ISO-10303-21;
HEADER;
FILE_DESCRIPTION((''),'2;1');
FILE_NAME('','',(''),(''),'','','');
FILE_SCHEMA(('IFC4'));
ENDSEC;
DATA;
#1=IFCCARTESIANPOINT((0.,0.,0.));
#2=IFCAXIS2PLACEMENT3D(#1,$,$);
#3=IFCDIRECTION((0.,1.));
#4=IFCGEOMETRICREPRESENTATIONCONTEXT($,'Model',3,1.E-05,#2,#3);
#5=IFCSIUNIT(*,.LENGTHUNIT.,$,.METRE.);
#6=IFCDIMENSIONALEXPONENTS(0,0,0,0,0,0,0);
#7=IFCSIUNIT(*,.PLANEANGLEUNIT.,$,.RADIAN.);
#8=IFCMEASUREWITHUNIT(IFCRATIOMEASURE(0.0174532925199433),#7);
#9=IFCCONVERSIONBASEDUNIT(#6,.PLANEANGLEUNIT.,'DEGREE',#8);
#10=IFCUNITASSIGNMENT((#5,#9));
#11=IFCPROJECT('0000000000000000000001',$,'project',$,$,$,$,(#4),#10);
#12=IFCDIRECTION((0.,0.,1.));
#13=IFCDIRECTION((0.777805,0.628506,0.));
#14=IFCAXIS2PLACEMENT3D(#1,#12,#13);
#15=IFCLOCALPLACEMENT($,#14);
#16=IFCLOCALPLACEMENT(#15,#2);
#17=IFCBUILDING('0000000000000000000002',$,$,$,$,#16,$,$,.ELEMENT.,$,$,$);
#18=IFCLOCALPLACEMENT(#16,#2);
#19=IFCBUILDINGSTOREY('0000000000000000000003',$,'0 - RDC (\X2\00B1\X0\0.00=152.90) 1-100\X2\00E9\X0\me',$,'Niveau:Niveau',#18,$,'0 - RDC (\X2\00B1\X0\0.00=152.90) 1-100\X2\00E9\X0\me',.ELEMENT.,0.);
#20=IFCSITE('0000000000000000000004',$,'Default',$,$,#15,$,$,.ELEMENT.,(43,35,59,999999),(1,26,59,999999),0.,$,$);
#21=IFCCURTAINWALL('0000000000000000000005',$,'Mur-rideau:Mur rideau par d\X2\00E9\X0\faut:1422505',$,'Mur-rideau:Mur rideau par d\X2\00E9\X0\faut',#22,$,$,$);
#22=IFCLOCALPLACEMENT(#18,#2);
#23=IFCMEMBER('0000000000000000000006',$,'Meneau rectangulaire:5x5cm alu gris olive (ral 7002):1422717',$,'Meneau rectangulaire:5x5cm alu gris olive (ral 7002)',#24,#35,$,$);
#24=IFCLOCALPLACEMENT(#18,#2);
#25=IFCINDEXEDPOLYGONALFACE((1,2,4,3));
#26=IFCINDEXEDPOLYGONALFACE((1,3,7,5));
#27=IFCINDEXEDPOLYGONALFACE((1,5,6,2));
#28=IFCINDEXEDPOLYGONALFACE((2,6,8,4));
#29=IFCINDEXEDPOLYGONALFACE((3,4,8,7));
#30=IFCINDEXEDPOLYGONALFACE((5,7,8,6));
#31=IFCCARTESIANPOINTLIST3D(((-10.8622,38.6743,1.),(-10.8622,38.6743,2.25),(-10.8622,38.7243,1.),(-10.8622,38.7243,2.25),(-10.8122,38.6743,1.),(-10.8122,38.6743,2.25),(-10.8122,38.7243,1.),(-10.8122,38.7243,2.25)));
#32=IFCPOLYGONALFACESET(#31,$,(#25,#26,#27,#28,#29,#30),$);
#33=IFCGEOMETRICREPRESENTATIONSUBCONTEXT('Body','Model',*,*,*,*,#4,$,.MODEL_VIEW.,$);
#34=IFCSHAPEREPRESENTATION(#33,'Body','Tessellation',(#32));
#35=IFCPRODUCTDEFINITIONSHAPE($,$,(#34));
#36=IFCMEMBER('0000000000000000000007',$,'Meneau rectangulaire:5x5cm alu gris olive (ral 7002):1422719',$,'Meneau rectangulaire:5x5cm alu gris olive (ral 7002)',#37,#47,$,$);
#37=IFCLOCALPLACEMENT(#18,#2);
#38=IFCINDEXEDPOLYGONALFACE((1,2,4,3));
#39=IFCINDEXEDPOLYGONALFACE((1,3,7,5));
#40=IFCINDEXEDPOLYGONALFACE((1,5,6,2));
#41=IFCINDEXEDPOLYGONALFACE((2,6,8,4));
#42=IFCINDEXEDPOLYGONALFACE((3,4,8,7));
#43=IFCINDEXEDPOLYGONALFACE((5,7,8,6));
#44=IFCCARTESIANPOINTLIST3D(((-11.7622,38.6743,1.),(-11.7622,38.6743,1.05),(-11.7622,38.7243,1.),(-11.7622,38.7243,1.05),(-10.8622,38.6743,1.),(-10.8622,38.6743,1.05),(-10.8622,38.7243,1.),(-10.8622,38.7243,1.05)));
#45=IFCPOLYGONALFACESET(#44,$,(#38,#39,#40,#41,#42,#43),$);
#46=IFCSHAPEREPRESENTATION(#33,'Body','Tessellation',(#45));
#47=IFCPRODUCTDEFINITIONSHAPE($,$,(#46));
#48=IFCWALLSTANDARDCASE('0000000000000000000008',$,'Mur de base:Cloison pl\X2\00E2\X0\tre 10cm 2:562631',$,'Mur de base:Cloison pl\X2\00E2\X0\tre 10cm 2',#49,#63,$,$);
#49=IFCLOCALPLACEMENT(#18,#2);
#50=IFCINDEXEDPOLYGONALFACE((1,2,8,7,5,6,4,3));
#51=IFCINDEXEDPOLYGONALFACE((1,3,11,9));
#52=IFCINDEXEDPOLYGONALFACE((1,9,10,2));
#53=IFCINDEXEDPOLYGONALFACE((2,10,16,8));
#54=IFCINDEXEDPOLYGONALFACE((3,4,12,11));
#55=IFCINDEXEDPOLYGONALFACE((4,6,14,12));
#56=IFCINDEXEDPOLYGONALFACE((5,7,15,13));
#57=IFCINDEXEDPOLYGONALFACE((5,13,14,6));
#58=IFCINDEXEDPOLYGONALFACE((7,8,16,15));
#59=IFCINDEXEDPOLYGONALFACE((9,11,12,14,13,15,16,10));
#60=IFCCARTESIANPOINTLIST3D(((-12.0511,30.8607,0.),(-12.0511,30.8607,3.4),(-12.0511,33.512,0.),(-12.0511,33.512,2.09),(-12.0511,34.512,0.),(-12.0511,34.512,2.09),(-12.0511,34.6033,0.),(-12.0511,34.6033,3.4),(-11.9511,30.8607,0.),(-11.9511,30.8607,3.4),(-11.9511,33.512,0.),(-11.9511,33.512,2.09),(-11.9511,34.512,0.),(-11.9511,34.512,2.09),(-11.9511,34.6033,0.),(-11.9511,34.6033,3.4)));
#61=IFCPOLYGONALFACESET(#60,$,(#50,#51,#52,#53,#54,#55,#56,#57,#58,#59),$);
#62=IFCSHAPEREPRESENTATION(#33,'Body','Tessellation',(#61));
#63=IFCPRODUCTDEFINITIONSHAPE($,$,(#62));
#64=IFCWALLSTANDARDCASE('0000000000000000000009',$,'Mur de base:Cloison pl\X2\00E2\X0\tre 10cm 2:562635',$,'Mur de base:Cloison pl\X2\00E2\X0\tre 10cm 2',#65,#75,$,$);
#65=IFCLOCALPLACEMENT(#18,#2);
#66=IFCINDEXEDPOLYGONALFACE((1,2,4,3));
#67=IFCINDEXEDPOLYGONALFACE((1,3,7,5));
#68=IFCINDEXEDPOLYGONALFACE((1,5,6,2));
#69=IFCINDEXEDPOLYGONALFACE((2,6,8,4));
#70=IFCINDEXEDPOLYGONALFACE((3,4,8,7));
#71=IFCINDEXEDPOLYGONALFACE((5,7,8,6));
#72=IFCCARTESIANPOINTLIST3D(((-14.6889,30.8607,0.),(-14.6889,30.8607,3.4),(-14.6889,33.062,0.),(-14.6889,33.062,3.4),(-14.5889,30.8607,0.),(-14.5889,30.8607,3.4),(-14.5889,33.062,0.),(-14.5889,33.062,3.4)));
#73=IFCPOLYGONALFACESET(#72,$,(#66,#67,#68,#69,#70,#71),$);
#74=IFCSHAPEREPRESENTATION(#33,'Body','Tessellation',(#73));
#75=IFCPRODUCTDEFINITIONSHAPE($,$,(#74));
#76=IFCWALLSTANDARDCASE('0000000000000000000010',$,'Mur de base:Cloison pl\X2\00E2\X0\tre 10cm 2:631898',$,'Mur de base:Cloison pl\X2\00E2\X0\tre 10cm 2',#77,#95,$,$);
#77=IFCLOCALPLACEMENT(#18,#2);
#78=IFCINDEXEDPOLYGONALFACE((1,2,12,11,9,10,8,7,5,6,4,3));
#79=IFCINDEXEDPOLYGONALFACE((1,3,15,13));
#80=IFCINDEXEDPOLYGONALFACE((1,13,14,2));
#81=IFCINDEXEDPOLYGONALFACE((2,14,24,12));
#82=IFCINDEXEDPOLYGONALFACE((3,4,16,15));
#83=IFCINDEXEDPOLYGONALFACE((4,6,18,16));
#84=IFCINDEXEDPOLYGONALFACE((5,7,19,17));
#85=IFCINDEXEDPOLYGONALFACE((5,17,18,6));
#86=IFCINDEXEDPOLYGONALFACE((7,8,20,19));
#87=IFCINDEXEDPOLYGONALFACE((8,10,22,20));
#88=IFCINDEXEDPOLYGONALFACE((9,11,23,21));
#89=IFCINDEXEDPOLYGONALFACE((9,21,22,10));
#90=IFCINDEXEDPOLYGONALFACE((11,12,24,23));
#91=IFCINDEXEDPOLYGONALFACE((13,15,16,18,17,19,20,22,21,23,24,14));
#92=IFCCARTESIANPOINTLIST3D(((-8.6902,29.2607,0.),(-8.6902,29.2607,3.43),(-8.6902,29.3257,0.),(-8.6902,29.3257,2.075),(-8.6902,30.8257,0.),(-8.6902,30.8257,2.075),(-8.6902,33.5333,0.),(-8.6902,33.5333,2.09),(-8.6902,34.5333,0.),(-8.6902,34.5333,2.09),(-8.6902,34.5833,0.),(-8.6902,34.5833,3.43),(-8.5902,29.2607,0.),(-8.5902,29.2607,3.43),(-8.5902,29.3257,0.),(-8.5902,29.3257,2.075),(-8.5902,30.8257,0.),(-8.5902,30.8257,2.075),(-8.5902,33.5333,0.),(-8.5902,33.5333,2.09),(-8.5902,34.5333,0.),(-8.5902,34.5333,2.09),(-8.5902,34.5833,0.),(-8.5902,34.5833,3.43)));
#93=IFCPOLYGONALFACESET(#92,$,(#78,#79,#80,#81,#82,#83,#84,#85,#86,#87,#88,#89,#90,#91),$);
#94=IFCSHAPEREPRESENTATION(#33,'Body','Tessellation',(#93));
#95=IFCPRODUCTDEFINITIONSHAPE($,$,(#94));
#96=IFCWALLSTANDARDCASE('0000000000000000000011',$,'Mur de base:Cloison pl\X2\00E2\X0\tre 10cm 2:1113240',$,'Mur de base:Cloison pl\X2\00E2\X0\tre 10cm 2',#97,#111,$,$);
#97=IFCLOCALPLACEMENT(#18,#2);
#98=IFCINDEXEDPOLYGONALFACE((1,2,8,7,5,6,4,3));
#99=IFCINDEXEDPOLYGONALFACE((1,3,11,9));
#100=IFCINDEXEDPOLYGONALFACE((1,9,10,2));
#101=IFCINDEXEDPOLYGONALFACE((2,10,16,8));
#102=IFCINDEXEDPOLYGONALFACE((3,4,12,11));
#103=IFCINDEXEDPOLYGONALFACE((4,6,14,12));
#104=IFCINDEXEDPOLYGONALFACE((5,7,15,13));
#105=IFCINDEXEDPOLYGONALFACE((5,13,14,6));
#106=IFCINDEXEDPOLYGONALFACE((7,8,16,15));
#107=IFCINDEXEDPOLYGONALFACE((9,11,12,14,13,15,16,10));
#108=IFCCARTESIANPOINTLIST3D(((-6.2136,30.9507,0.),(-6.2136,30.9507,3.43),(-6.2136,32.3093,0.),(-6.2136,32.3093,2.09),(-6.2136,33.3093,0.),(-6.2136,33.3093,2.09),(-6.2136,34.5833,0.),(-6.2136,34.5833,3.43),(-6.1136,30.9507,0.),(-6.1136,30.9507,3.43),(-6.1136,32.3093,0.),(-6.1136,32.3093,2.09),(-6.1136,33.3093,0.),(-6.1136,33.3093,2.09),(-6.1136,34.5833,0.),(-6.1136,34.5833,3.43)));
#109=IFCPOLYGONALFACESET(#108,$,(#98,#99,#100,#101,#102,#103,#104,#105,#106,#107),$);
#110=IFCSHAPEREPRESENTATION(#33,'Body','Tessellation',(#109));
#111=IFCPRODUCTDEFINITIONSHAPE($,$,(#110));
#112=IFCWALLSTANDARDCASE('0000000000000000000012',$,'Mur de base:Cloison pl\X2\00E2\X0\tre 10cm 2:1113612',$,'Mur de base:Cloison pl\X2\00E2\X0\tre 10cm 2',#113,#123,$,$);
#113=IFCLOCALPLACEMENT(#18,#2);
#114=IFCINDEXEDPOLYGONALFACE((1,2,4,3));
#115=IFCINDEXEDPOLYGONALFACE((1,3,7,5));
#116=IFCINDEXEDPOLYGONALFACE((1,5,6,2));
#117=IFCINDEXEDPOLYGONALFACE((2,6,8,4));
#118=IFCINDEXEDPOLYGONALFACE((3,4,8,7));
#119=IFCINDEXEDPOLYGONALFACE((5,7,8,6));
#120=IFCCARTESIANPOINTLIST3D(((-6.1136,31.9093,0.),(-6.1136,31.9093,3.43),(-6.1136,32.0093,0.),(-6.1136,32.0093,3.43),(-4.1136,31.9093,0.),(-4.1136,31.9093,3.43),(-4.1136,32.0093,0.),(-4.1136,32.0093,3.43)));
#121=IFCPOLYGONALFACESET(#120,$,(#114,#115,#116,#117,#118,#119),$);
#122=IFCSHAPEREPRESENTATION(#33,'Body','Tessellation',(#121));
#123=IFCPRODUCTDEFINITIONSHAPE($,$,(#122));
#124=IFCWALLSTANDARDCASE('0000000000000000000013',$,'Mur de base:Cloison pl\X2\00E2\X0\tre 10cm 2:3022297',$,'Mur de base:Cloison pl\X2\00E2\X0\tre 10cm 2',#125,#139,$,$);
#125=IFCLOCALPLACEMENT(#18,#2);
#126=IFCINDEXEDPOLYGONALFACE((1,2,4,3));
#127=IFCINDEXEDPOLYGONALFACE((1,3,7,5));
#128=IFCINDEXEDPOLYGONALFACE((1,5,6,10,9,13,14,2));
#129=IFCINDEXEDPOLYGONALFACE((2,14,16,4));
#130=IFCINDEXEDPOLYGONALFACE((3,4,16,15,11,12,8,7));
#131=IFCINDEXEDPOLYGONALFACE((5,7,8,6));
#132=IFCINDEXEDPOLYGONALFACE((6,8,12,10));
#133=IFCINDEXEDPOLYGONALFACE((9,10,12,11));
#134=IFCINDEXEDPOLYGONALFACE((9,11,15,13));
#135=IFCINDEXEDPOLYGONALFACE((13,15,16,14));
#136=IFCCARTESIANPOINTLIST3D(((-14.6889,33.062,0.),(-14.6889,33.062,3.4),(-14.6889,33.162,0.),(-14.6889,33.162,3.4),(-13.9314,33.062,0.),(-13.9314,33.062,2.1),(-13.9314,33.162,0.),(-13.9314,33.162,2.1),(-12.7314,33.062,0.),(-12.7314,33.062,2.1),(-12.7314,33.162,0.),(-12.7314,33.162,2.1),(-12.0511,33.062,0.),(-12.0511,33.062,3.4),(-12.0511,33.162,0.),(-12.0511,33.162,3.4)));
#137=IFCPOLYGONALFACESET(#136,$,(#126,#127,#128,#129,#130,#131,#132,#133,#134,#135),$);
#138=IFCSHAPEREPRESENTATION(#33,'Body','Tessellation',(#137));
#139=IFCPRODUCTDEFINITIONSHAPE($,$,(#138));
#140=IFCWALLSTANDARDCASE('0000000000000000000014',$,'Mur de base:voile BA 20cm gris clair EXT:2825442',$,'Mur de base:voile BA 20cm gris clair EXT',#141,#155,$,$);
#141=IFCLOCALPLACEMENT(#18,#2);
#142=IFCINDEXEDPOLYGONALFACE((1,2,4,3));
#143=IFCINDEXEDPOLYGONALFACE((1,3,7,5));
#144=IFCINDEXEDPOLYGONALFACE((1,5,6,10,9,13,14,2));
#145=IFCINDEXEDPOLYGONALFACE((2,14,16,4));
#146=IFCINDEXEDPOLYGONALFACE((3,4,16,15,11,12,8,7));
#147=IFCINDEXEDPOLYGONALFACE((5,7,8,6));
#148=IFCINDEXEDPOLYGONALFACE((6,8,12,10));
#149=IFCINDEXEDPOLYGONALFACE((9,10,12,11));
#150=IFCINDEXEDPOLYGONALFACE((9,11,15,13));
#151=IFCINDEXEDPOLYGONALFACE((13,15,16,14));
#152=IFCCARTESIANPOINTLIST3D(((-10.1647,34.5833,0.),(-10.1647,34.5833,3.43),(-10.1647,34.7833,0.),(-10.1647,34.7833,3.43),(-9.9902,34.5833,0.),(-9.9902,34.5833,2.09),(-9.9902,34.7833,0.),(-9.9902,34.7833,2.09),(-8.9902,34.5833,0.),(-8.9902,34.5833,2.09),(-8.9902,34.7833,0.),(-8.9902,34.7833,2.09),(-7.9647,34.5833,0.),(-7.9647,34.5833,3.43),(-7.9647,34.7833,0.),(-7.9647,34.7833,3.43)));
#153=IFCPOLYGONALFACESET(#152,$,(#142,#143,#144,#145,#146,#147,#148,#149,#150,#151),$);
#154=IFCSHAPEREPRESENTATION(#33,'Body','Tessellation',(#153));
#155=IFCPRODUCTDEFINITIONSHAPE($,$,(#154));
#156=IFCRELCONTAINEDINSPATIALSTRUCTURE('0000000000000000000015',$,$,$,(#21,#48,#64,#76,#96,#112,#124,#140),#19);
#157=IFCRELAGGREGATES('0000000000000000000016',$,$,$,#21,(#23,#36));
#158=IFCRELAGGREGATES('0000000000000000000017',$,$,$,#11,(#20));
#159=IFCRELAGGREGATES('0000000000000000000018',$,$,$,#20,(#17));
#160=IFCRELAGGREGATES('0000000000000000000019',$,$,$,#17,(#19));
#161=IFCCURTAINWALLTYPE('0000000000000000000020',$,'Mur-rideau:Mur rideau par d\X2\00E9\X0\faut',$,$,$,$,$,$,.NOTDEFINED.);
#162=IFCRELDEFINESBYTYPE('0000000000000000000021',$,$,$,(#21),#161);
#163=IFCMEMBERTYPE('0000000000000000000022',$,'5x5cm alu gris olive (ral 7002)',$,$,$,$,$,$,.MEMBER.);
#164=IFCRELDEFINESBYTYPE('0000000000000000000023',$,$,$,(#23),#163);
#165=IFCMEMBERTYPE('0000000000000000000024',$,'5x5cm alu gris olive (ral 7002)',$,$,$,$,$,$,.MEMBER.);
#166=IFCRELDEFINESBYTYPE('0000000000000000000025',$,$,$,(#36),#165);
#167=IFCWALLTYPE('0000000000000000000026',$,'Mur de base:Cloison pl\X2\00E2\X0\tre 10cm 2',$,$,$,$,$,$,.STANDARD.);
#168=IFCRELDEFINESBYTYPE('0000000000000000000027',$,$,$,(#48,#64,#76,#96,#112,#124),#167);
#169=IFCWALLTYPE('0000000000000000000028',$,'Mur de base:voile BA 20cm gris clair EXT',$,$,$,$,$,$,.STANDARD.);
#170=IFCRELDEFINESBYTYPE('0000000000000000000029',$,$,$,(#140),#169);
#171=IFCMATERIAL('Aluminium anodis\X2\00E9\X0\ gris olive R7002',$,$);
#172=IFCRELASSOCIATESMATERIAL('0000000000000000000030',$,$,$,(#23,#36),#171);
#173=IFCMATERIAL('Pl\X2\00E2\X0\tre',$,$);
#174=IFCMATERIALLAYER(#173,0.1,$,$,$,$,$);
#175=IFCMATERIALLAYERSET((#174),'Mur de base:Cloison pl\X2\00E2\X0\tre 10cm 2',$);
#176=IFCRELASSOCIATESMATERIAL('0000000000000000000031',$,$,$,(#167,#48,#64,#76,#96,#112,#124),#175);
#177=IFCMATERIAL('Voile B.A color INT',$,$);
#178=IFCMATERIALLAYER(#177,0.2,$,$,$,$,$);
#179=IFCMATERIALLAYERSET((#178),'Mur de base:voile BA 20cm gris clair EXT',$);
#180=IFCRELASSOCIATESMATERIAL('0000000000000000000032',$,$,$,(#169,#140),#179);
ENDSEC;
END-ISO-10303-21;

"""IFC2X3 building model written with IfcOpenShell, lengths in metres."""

from ifc_helpers import new_model, entity, si_unit, converted_unit, direction, frame, frame_2d, origin, origin_2d_with_axis, place, context, subcontext, project, spatial, polyline, rectangle, extrude, clip, bounded_halfspace, source, transform, mapped, material, layer, layer_set, layer_usage, type_object, type_shapes, element, aggregate, save


model = new_model("IFC2X3")

# Units and contexts
model_context = context("Model", 3, precision=1e-05, world=origin(), true_north=direction((0.0, 1.0)))
body_context = subcontext(model_context, "Body", "Model", "MODEL_VIEW")
ifc_project = project(units=[si_unit("LENGTHUNIT", "METRE"), converted_unit("PLANEANGLEUNIT", "DEGREE", entity("IfcRatioMeasure", 0.0174532925199433), si_unit("PLANEANGLEUNIT", "RADIAN"), dimensions=[0, 0, 0, 0, 0, 0, 0])], contexts=[model_context])

# Site, building, storey
site_placement = place(None, frame((0.0, 0.0, 0.0), z_axis=(0.0, 0.0, 1.0), x_axis=(0.777805, 0.628506, 0.0)))
site = spatial("IfcSite", under=ifc_project, at=site_placement, Name="Default", CompositionType="ELEMENT", RefLatitude=(43, 35, 59, 999999), RefLongitude=(1, 26, 59, 999999), RefElevation=0.0)
building_placement = place(site_placement, origin())
building = spatial("IfcBuilding", under=site, at=building_placement, CompositionType="ELEMENT")
storey_placement = place(building_placement, origin())
storey = spatial("IfcBuildingStorey", under=building, at=storey_placement, Name="0 - RDC (±0.00=152.90) 1-100éme", ObjectType="Niveau:Niveau", LongName="0 - RDC (±0.00=152.90) 1-100éme", CompositionType="ELEMENT", Elevation=0.0)

# Curtain wall, members
curtain_wall_type = type_object("IfcCurtainWallType", Name="Mur-rideau:Mur rideau par défaut", PredefinedType="NOTDEFINED")
curtain_wall_placement = place(storey_placement, origin())
curtain_wall = element("IfcCurtainWall", 1, at=curtain_wall_placement, inside=storey, type_object=curtain_wall_type, Name="Mur-rideau:Mur rideau par défaut:1422505", ObjectType="Mur-rideau:Mur rideau par défaut")
ifc_material_1 = material(Name="Aluminium anodisé gris olive R7002")
member_type_1 = type_object("IfcMemberType", Name="5x5cm alu gris olive (ral 7002)", PredefinedType="MEMBER")
shared_shape_1 = source(origin(), body_context, "Body", "SweptSolid", [
    extrude(rectangle(XDim=0.05, YDim=0.05, at=origin_2d_with_axis()), frame((-0.025, 0.0, -1.25), z_axis=(0.0, 0.0, 1.0), x_axis=(0.0, -1.0, 0.0)), (0.0, 0.0, 1.0), 1.25),
])
type_shapes(member_type_1, [shared_shape_1])
member_1_placement = place(storey_placement, frame((-10.8122, 38.6993, 2.25)))
member_1 = element("IfcMember", 2, at=member_1_placement, type_object=member_type_1, material=ifc_material_1, Name="Meneau rectangulaire:5x5cm alu gris olive (ral 7002):1422717", ObjectType="Meneau rectangulaire:5x5cm alu gris olive (ral 7002)", context=body_context, shape_type="MappedRepresentation", body=[
    mapped(shared_shape_1, transform((0.0, 0.0, 0.0), scale=1.0)),
])
member_type_2 = type_object("IfcMemberType", Name="5x5cm alu gris olive (ral 7002)", PredefinedType="MEMBER")
shared_shape_2 = source(origin(), body_context, "Body", "SweptSolid", [
    extrude(rectangle(XDim=0.05, YDim=0.05, at=origin_2d_with_axis()), frame((-0.025, 0.0, -0.9), z_axis=(0.0, 0.0, 1.0), x_axis=(0.0, -1.0, 0.0)), (0.0, 0.0, 1.0), 0.9),
])
type_shapes(member_type_2, [shared_shape_2])
member_2_placement = place(storey_placement, frame((-10.8622, 38.6993, 1.0), z_axis=(1.0, 0.0, 0.0), x_axis=(0.0, 0.0, -1.0)))
member_2 = element("IfcMember", 3, at=member_2_placement, type_object=member_type_2, material=ifc_material_1, Name="Meneau rectangulaire:5x5cm alu gris olive (ral 7002):1422719", ObjectType="Meneau rectangulaire:5x5cm alu gris olive (ral 7002)", context=body_context, shape_type="MappedRepresentation", body=[
    mapped(shared_shape_2, transform((0.0, 0.0, 0.0), scale=1.0)),
])
aggregate(curtain_wall, [member_1, member_2])

# Wall, opening
ifc_material_2 = material(Name="Plâtre")
ifc_layer_1 = layer(ifc_material_2, 0.1)
ifc_layer_set_1 = layer_set([ifc_layer_1], Name="Mur de base:Cloison plâtre 10cm 2")
ifc_layer_usage_1 = layer_usage(ifc_layer_set_1, "AXIS2", "NEGATIVE", 0.05)
wall_type_1 = type_object("IfcWallType", Name="Mur de base:Cloison plâtre 10cm 2", PredefinedType="STANDARD", material=ifc_layer_set_1)
wall_1_placement = place(storey_placement, frame((-12.0011, 34.6033, 0.0), z_axis=(0.0, 0.0, 1.0), x_axis=(0.0, -1.0, 0.0)))
wall_1 = element("IfcWallStandardCase", 4, at=wall_1_placement, inside=storey, type_object=wall_type_1, material=ifc_layer_usage_1, Name="Mur de base:Cloison plâtre 10cm 2:562631", ObjectType="Mur de base:Cloison plâtre 10cm 2", context=body_context, shape_type="SweptSolid", body=[
    extrude(rectangle(XDim=3.7426, YDim=0.1, at=frame_2d((1.8713, 0.0), x_axis=(-1.0, 0.0))), origin(), (0.0, 0.0, 1.0), 3.4),
])
opening_1_placement = place(wall_1_placement, frame((1.0912, 0.05, 0.0)))
element("IfcOpeningElement", 5, at=opening_1_placement, cuts=wall_1, ObjectType="Opening", context=body_context, shape_type="SweptSolid", body=[
    extrude(rectangle(XDim=2.09, YDim=1.0, at=frame_2d((1.045, 0.5), x_axis=(1.0, 0.0))), frame((0.0, 0.0, 0.0), z_axis=(0.0, -1.0, 0.0), x_axis=(0.0, 0.0, 1.0)), (0.0, 0.0, 1.0), 0.1),
])

# Wall
ifc_layer_usage_2 = layer_usage(ifc_layer_set_1, "AXIS2", "NEGATIVE", 0.05)
wall_2_placement = place(storey_placement, frame((-14.6389, 33.062, 0.0), z_axis=(0.0, 0.0, 1.0), x_axis=(0.0, -1.0, 0.0)))
element("IfcWallStandardCase", 6, at=wall_2_placement, inside=storey, type_object=wall_type_1, material=ifc_layer_usage_2, Name="Mur de base:Cloison plâtre 10cm 2:562635", ObjectType="Mur de base:Cloison plâtre 10cm 2", context=body_context, shape_type="Clipping", body=[
    clip(extrude(rectangle(XDim=2.2013, YDim=0.1, at=frame_2d((1.1007, 0.0), x_axis=(-1.0, 0.0))), origin(), (0.0, 0.0, 1.0), 3.4), bounded_halfspace(frame((0.0, -0.05, 0.0), z_axis=(1.0, 0.0, 0.0), x_axis=(0.0, 1.0, 0.0)), True, frame((0.0, -0.05, 0.0), z_axis=(1.0, 0.0, 0.0), x_axis=(0.0, 1.0, 0.0)), polyline([(0.0, 0.0), (0.1, 0.0), (0.1, 3.4), (0.0, 3.4), (0.0, 0.0)]))),
])

# Wall, openings
ifc_layer_usage_3 = layer_usage(ifc_layer_set_1, "AXIS2", "NEGATIVE", 0.05)
wall_3_placement = place(storey_placement, frame((-8.6402, 29.2607, 0.0), z_axis=(0.0, 0.0, 1.0), x_axis=(0.0, 1.0, 0.0)))
wall_3 = element("IfcWallStandardCase", 7, at=wall_3_placement, inside=storey, type_object=wall_type_1, material=ifc_layer_usage_3, Name="Mur de base:Cloison plâtre 10cm 2:631898", ObjectType="Mur de base:Cloison plâtre 10cm 2", context=body_context, shape_type="SweptSolid", body=[
    extrude(rectangle(XDim=5.3226, YDim=0.1, at=frame_2d((2.6613, 0.0), x_axis=(-1.0, 0.0))), origin(), (0.0, 0.0, 1.0), 3.43),
])
opening_2_placement = place(wall_3_placement, frame((1.565, 0.05, 0.0)))
element("IfcOpeningElement", 8, at=opening_2_placement, cuts=wall_3, ObjectType="Opening", context=body_context, shape_type="SweptSolid", body=[
    extrude(rectangle(XDim=2.075, YDim=1.5, at=frame_2d((1.0375, 0.75), x_axis=(1.0, 0.0))), frame((0.0, 0.0, 0.0), z_axis=(0.0, -1.0, 0.0), x_axis=(0.0, 0.0, 1.0)), (0.0, 0.0, 1.0), 0.1),
])
opening_3_placement = place(wall_3_placement, frame((5.2726, 0.05, 0.0)))
element("IfcOpeningElement", 9, at=opening_3_placement, cuts=wall_3, ObjectType="Opening", context=body_context, shape_type="SweptSolid", body=[
    extrude(rectangle(XDim=2.09, YDim=1.0, at=frame_2d((1.045, 0.5), x_axis=(1.0, 0.0))), frame((0.0, 0.0, 0.0), z_axis=(0.0, -1.0, 0.0), x_axis=(0.0, 0.0, 1.0)), (0.0, 0.0, 1.0), 0.1),
])

# Wall, opening
ifc_layer_usage_4 = layer_usage(ifc_layer_set_1, "AXIS2", "NEGATIVE", 0.05)
wall_4_placement = place(storey_placement, frame((-6.1636, 34.5833, 0.0), z_axis=(0.0, 0.0, 1.0), x_axis=(0.0, -1.0, 0.0)))
wall_4 = element("IfcWallStandardCase", 10, at=wall_4_placement, inside=storey, type_object=wall_type_1, material=ifc_layer_usage_4, Name="Mur de base:Cloison plâtre 10cm 2:1113240", ObjectType="Mur de base:Cloison plâtre 10cm 2", context=body_context, shape_type="SweptSolid", body=[
    extrude(rectangle(XDim=3.6326, YDim=0.1, at=frame_2d((1.8163, 0.0), x_axis=(-1.0, 0.0))), origin(), (0.0, 0.0, 1.0), 3.43),
])
opening_4_placement = place(wall_4_placement, frame((2.2739, 0.05, 0.0)))
element("IfcOpeningElement", 11, at=opening_4_placement, cuts=wall_4, ObjectType="Opening", context=body_context, shape_type="SweptSolid", body=[
    extrude(rectangle(XDim=2.09, YDim=1.0, at=frame_2d((1.045, 0.5), x_axis=(1.0, 0.0))), frame((0.0, 0.0, 0.0), z_axis=(0.0, -1.0, 0.0), x_axis=(0.0, 0.0, 1.0)), (0.0, 0.0, 1.0), 0.1),
])

# Wall
ifc_layer_usage_5 = layer_usage(ifc_layer_set_1, "AXIS2", "NEGATIVE", 0.05)
wall_5_placement = place(storey_placement, frame((-6.1136, 31.9593, 0.0)))
element("IfcWallStandardCase", 12, at=wall_5_placement, inside=storey, type_object=wall_type_1, material=ifc_layer_usage_5, Name="Mur de base:Cloison plâtre 10cm 2:1113612", ObjectType="Mur de base:Cloison plâtre 10cm 2", context=body_context, shape_type="SweptSolid", body=[
    extrude(rectangle(XDim=2.0, YDim=0.1, at=frame_2d((1.0, 0.0), x_axis=(-1.0, 0.0))), origin(), (0.0, 0.0, 1.0), 3.43),
])

# Walls, openings
ifc_layer_usage_6 = layer_usage(ifc_layer_set_1, "AXIS2", "NEGATIVE", 0.05)
wall_6_placement = place(storey_placement, frame((-14.6889, 33.112, 0.0)))
wall_6 = element("IfcWallStandardCase", 13, at=wall_6_placement, inside=storey, type_object=wall_type_1, material=ifc_layer_usage_6, Name="Mur de base:Cloison plâtre 10cm 2:3022297", ObjectType="Mur de base:Cloison plâtre 10cm 2", context=body_context, shape_type="SweptSolid", body=[
    extrude(rectangle(XDim=2.6377, YDim=0.1, at=frame_2d((1.3189, 0.0), x_axis=(-1.0, 0.0))), origin(), (0.0, 0.0, 1.0), 3.4),
])
opening_5_placement = place(wall_6_placement, origin())
element("IfcOpeningElement", 14, at=opening_5_placement, cuts=wall_6, ObjectType="Opening", context=body_context, shape_type="SweptSolid", body=[
    extrude(rectangle(XDim=2.1, YDim=1.2, at=origin_2d_with_axis()), frame((1.3575, -0.05, 1.05), z_axis=(0.0, 1.0, 0.0), x_axis=(0.0, 0.0, -1.0)), (0.0, 0.0, 1.0), 0.1),
])
ifc_material_3 = material(Name="Voile B.A color INT")
ifc_layer_2 = layer(ifc_material_3, 0.2)
ifc_layer_set_2 = layer_set([ifc_layer_2], Name="Mur de base:voile BA 20cm gris clair EXT")
ifc_layer_usage_7 = layer_usage(ifc_layer_set_2, "AXIS2", "NEGATIVE", 0.1)
wall_type_2 = type_object("IfcWallType", Name="Mur de base:voile BA 20cm gris clair EXT", PredefinedType="STANDARD", material=ifc_layer_set_2)
wall_7_placement = place(storey_placement, frame((-10.1647, 34.6833, 0.0)))
wall_7 = element("IfcWallStandardCase", 15, at=wall_7_placement, inside=storey, type_object=wall_type_2, material=ifc_layer_usage_7, Name="Mur de base:voile BA 20cm gris clair EXT:2825442", ObjectType="Mur de base:voile BA 20cm gris clair EXT", context=body_context, shape_type="SweptSolid", body=[
    extrude(rectangle(XDim=2.2, YDim=0.2, at=frame_2d((1.1, 0.0), x_axis=(-1.0, 0.0))), origin(), (0.0, 0.0, 1.0), 3.43),
])
opening_6_placement = place(wall_7_placement, frame((0.1746, -0.1, 0.0)))
element("IfcOpeningElement", 16, at=opening_6_placement, cuts=wall_7, ObjectType="Opening", context=body_context, shape_type="SweptSolid", body=[
    extrude(rectangle(XDim=2.09, YDim=1.0, at=frame_2d((1.045, 0.5), x_axis=(1.0, 0.0))), frame((0.0, 0.0, 0.0), z_axis=(0.0, 1.0, 0.0), x_axis=(0.0, 0.0, 1.0)), (0.0, 0.0, 1.0), 0.2),
])

save(model, "model.ifc")
